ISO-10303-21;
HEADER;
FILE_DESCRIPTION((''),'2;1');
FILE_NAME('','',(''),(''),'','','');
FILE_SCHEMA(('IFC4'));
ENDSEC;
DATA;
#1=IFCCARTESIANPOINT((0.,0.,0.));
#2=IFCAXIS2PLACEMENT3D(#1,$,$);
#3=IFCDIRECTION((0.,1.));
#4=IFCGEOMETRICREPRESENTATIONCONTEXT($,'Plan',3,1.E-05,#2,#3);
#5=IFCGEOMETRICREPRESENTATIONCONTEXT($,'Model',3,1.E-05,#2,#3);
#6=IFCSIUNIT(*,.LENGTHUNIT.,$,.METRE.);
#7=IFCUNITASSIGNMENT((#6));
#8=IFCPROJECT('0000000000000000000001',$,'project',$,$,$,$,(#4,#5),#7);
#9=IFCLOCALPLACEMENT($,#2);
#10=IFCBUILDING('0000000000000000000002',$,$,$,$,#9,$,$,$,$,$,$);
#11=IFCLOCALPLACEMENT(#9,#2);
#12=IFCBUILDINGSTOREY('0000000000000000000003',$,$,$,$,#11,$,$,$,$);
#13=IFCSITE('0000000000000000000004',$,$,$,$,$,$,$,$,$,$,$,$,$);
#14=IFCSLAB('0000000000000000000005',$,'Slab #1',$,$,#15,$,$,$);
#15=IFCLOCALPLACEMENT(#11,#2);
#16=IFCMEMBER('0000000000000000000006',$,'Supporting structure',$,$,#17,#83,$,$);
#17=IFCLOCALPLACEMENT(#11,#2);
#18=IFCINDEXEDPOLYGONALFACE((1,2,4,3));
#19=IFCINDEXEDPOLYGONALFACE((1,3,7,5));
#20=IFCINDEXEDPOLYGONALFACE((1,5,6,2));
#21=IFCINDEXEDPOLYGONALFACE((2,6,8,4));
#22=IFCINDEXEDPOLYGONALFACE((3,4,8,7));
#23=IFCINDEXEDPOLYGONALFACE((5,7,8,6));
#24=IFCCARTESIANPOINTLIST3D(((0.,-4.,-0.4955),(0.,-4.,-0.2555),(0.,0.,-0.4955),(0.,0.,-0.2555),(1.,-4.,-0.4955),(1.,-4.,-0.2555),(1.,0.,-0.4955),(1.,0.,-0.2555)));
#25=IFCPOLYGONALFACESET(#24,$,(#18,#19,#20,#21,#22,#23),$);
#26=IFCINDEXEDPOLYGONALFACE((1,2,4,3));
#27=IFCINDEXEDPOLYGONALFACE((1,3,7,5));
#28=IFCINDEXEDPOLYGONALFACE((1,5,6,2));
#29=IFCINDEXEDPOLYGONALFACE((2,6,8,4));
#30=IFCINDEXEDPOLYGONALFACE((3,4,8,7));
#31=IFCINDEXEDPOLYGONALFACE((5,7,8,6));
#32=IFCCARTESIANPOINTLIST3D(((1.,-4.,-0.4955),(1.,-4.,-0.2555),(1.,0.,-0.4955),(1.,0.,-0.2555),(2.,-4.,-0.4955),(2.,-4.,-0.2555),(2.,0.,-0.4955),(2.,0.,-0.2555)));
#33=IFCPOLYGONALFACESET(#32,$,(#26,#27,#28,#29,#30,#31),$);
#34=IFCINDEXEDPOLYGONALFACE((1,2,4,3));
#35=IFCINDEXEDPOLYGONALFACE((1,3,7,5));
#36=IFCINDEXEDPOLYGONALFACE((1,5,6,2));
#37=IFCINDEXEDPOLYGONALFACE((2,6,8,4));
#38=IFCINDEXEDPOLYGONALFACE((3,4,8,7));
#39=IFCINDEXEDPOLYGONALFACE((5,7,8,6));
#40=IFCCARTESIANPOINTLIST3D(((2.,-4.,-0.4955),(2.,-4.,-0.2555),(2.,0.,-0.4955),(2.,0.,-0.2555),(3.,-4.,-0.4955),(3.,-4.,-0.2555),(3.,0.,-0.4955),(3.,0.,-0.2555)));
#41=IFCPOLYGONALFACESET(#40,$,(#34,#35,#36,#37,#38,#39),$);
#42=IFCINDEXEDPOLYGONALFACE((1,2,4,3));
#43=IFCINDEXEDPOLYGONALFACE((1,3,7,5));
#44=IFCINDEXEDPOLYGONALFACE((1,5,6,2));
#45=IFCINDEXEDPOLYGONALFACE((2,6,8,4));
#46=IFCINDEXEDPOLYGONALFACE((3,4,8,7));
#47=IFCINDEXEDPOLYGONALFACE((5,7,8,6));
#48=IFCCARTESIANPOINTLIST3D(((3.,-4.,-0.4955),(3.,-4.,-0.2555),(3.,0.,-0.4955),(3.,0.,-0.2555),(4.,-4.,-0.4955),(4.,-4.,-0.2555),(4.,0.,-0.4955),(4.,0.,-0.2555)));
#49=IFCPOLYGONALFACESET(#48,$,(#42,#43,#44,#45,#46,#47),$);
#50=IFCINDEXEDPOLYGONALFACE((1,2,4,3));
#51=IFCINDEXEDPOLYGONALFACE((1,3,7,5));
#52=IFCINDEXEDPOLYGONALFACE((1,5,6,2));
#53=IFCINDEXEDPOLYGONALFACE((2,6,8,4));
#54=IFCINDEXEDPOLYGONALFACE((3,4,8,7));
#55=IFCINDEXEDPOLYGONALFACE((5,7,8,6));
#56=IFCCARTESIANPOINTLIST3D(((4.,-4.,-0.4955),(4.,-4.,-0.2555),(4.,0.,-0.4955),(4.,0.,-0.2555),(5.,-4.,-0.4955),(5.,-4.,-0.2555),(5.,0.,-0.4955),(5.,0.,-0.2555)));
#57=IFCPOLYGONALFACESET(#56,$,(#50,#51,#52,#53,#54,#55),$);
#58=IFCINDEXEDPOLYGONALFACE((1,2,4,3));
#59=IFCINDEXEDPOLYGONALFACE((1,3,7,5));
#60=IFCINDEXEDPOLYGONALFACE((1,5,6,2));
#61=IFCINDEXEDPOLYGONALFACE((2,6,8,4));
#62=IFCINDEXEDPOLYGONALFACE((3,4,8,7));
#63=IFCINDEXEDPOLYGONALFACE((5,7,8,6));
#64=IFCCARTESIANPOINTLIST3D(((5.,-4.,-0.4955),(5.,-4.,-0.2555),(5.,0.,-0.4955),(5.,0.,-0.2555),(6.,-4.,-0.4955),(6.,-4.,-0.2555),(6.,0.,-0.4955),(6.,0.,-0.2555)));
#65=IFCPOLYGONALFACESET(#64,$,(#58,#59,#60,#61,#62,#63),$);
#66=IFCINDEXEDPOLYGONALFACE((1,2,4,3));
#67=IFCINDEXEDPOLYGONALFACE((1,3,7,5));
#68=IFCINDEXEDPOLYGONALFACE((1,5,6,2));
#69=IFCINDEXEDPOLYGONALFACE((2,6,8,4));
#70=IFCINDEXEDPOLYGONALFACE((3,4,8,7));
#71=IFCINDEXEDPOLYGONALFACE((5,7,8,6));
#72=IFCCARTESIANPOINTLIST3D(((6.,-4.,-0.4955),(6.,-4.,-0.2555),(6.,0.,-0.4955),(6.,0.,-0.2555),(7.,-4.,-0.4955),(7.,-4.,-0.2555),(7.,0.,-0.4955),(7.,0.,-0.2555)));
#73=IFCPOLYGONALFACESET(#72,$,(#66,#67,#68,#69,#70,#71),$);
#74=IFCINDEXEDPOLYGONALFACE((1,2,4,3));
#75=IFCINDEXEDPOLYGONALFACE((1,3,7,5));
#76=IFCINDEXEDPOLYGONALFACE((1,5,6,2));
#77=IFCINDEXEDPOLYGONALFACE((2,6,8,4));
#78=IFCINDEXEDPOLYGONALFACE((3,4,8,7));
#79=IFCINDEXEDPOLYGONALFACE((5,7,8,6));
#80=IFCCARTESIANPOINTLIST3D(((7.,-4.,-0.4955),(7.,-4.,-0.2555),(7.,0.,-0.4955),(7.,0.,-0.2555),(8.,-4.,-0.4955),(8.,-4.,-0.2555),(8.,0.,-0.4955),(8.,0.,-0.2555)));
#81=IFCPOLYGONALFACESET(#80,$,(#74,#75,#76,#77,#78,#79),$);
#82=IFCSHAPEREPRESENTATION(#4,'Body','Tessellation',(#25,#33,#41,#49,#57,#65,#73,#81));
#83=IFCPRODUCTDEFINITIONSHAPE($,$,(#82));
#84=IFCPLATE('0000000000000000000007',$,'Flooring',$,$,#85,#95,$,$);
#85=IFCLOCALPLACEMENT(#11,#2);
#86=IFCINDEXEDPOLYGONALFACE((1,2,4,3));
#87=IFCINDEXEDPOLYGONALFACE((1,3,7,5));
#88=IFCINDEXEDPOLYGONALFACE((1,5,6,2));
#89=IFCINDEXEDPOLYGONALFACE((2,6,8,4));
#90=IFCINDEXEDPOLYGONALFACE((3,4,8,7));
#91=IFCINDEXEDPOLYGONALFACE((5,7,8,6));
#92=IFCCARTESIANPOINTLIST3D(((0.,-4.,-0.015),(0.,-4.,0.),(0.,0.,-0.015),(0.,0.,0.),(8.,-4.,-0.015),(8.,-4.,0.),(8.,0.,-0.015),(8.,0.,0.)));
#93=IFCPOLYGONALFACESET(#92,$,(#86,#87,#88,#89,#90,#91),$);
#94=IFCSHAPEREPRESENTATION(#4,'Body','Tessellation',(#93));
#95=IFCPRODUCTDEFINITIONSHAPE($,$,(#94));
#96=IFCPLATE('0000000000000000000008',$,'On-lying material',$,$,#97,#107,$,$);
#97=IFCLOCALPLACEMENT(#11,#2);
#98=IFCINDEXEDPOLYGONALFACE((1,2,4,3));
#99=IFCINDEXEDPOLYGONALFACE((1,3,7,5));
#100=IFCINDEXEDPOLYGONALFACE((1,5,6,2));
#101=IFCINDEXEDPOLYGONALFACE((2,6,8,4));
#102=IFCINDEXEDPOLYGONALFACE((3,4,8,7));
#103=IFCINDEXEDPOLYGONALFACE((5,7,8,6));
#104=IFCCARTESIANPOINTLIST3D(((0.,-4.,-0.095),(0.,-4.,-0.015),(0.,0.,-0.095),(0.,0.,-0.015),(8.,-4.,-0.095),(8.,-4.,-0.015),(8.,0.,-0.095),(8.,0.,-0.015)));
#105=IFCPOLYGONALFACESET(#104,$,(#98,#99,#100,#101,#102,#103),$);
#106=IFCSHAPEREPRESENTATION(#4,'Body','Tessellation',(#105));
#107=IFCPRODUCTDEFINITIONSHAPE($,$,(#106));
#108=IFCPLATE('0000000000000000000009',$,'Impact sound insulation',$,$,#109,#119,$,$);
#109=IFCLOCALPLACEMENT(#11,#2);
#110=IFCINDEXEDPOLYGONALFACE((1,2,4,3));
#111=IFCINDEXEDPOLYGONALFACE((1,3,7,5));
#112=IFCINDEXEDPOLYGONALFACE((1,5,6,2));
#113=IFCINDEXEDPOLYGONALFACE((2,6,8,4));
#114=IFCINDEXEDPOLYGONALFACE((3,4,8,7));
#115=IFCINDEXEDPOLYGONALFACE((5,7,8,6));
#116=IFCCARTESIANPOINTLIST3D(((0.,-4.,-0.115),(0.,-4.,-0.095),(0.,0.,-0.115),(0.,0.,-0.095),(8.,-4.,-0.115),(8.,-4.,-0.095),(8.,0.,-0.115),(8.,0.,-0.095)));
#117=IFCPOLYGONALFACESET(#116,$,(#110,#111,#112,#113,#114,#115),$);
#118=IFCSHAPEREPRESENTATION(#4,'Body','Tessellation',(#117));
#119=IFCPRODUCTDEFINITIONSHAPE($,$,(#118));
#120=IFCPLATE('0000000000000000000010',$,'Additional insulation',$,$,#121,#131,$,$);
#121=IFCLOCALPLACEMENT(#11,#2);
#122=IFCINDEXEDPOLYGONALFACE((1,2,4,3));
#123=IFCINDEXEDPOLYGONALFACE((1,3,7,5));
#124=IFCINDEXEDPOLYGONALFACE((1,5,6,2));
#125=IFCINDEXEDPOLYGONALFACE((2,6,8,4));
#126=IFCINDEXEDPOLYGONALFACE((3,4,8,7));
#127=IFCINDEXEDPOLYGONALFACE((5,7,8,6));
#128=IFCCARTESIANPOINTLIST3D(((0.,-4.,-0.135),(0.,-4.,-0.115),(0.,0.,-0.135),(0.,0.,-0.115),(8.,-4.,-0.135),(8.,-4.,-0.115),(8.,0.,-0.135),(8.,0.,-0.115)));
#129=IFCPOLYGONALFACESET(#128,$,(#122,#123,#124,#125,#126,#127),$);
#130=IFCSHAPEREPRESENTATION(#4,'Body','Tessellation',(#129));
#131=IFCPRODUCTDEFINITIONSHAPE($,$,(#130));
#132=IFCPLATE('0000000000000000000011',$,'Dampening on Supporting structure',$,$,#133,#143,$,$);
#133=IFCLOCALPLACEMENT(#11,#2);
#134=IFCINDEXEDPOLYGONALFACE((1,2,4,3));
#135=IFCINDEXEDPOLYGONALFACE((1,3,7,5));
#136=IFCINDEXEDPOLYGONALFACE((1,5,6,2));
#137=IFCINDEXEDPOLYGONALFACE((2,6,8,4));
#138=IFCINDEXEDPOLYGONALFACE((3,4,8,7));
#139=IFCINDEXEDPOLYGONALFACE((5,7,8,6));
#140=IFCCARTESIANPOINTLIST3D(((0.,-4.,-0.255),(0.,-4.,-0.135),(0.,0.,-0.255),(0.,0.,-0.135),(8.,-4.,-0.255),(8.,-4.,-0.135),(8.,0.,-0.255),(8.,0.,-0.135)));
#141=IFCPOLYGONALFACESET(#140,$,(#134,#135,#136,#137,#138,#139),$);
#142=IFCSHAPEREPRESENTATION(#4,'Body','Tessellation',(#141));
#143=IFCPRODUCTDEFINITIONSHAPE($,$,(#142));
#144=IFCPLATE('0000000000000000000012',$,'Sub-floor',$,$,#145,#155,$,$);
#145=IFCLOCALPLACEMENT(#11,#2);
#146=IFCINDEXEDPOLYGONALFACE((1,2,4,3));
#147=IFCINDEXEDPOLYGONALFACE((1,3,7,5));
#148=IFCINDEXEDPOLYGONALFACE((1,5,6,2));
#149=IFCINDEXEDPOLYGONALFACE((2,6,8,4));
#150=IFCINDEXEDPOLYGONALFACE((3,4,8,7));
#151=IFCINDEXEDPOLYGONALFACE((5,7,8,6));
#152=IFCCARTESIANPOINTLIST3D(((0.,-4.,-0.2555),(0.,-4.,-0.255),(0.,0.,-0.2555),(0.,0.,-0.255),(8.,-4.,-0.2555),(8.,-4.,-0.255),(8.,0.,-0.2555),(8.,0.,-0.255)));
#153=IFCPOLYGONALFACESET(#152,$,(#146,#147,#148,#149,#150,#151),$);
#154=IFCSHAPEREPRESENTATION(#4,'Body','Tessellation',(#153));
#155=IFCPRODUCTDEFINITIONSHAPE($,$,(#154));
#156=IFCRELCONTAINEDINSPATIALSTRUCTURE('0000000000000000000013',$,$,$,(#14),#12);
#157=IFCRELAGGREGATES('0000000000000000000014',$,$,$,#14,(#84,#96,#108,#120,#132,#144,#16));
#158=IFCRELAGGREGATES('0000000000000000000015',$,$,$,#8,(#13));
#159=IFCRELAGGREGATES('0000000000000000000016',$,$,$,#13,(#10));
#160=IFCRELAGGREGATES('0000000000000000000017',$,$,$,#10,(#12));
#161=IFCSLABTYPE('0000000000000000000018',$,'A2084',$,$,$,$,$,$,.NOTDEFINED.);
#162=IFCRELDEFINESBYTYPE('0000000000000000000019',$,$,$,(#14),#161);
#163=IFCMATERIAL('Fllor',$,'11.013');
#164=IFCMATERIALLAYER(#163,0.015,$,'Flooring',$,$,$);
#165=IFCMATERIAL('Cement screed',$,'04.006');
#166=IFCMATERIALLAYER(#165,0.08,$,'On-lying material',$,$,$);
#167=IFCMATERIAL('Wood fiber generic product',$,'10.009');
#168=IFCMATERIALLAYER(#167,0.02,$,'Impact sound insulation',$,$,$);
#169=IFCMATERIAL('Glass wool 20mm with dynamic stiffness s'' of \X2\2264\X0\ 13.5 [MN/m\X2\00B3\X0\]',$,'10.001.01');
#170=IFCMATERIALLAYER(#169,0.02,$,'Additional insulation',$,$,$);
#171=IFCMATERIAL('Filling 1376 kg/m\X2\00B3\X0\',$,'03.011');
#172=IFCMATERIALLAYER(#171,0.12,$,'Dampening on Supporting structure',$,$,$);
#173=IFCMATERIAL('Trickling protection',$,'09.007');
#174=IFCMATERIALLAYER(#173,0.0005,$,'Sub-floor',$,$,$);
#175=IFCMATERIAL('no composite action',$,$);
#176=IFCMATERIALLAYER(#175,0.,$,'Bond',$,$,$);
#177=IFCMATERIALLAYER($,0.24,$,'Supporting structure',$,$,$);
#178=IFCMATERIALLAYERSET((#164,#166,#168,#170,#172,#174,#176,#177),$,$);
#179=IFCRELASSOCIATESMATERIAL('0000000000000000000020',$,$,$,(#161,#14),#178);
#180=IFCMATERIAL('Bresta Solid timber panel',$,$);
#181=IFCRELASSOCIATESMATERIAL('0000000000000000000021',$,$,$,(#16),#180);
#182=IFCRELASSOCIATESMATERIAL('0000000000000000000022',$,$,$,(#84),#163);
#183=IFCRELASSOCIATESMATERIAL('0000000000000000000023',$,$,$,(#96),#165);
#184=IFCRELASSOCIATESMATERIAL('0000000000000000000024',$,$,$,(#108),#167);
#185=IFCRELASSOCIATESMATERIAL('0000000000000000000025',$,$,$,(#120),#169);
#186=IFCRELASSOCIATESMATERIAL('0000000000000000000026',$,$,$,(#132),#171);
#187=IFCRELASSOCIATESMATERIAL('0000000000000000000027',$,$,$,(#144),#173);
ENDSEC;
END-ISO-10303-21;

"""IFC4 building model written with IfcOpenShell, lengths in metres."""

from ifc_helpers import new_model, si_unit, direction, frame, frame_2d, origin, origin_with_axes, place, context, project, spatial, rectangle, extrude, material, layer, layer_set, type_object, element, aggregate, save


model = new_model("IFC4")

# Units and contexts
plan_context = context("Plan", 3, precision=1e-05, world=origin(), true_north=direction((0.0, 1.0)))
model_context = context("Model", 3, precision=1e-05, world=origin(), true_north=direction((0.0, 1.0)))
ifc_project = project(units=[si_unit("LENGTHUNIT", "METRE")], contexts=[plan_context, model_context])

# Site, building, storey
site = spatial("IfcSite", under=ifc_project)
building_placement = place(None, origin())
building = spatial("IfcBuilding", under=site, at=building_placement)
storey_placement = place(building_placement, origin())
storey = spatial("IfcBuildingStorey", under=building, at=storey_placement)

# Slab, member, plates
ifc_material_1 = material(Name="Fllor", Category="11.013")
ifc_layer_1 = layer(ifc_material_1, 0.015, Name="Flooring")
ifc_material_2 = material(Name="Cement screed", Category="04.006")
ifc_layer_2 = layer(ifc_material_2, 0.08, Name="On-lying material")
ifc_material_3 = material(Name="Wood fiber generic product", Category="10.009")
ifc_layer_3 = layer(ifc_material_3, 0.02, Name="Impact sound insulation")
ifc_material_4 = material(Name="Glass wool 20mm with dynamic stiffness s' of ≤ 13.5 [MN/m³]", Category="10.001.01")
ifc_layer_4 = layer(ifc_material_4, 0.02, Name="Additional insulation")
ifc_material_5 = material(Name="Filling 1376 kg/m³", Category="03.011")
ifc_layer_5 = layer(ifc_material_5, 0.12, Name="Dampening on Supporting structure")
ifc_material_6 = material(Name="Trickling protection", Category="09.007")
ifc_layer_6 = layer(ifc_material_6, 0.0005, Name="Sub-floor")
ifc_material_7 = material(Name="no composite action")
ifc_layer_7 = layer(ifc_material_7, 0.0, Name="Bond")
ifc_layer_8 = layer(None, 0.24, Name="Supporting structure")
ifc_layer_set = layer_set([ifc_layer_1, ifc_layer_2, ifc_layer_3, ifc_layer_4, ifc_layer_5, ifc_layer_6, ifc_layer_7, ifc_layer_8])
slab_type = type_object("IfcSlabType", Name="A2084", PredefinedType="NOTDEFINED", material=ifc_layer_set)
slab_placement = place(None, frame((0.0, 0.0, 0.0), z_axis=(0.0, 0.0, -1.0), x_axis=(1.0, 0.0, 0.0)))
slab = element("IfcSlab", 1, at=slab_placement, inside=storey, type_object=slab_type, material=ifc_layer_set, Name="Slab #1")
ifc_material_8 = material(Name="Bresta Solid timber panel")
member_placement = place(slab_placement, origin())
member = element("IfcMember", 2, at=member_placement, material=ifc_material_8, Name="Supporting structure", context=plan_context, shape_type="SweptSolid", body=[
    extrude(rectangle(XDim=1.0, YDim=0.24, at=frame_2d((0.5, 0.12), x_axis=(1.0, 0.0))), frame((0.0, 4.0, 0.2555), z_axis=(0.0, -1.0, 0.0), x_axis=(1.0, 0.0, 0.0)), (0.0, 0.0, 1.0), 4.0),
    extrude(rectangle(XDim=1.0, YDim=0.24, at=frame_2d((0.5, 0.12), x_axis=(1.0, 0.0))), frame((1.0, 4.0, 0.2555), z_axis=(0.0, -1.0, 0.0), x_axis=(1.0, 0.0, 0.0)), (0.0, 0.0, 1.0), 4.0),
    extrude(rectangle(XDim=1.0, YDim=0.24, at=frame_2d((0.5, 0.12), x_axis=(1.0, 0.0))), frame((2.0, 4.0, 0.2555), z_axis=(0.0, -1.0, 0.0), x_axis=(1.0, 0.0, 0.0)), (0.0, 0.0, 1.0), 4.0),
    extrude(rectangle(XDim=1.0, YDim=0.24, at=frame_2d((0.5, 0.12), x_axis=(1.0, 0.0))), frame((3.0, 4.0, 0.2555), z_axis=(0.0, -1.0, 0.0), x_axis=(1.0, 0.0, 0.0)), (0.0, 0.0, 1.0), 4.0),
    extrude(rectangle(XDim=1.0, YDim=0.24, at=frame_2d((0.5, 0.12), x_axis=(1.0, 0.0))), frame((4.0, 4.0, 0.2555), z_axis=(0.0, -1.0, 0.0), x_axis=(1.0, 0.0, 0.0)), (0.0, 0.0, 1.0), 4.0),
    extrude(rectangle(XDim=1.0, YDim=0.24, at=frame_2d((0.5, 0.12), x_axis=(1.0, 0.0))), frame((5.0, 4.0, 0.2555), z_axis=(0.0, -1.0, 0.0), x_axis=(1.0, 0.0, 0.0)), (0.0, 0.0, 1.0), 4.0),
    extrude(rectangle(XDim=1.0, YDim=0.24, at=frame_2d((0.5, 0.12), x_axis=(1.0, 0.0))), frame((6.0, 4.0, 0.2555), z_axis=(0.0, -1.0, 0.0), x_axis=(1.0, 0.0, 0.0)), (0.0, 0.0, 1.0), 4.0),
    extrude(rectangle(XDim=1.0, YDim=0.24, at=frame_2d((0.5, 0.12), x_axis=(1.0, 0.0))), frame((7.0, 4.0, 0.2555), z_axis=(0.0, -1.0, 0.0), x_axis=(1.0, 0.0, 0.0)), (0.0, 0.0, 1.0), 4.0),
])
plate_1_placement = place(slab_placement, origin())
plate_1 = element("IfcPlate", 3, at=plate_1_placement, material=ifc_material_1, Name="Flooring", context=plan_context, shape_type="SweptSolid", body=[
    extrude(rectangle(XDim=8.0, YDim=4.0, at=frame_2d((4.0, 2.0), x_axis=(1.0, 0.0))), origin_with_axes(), (0.0, 0.0, 1.0), 0.015),
])
plate_2_placement = place(slab_placement, origin())
plate_2 = element("IfcPlate", 4, at=plate_2_placement, material=ifc_material_2, Name="On-lying material", context=plan_context, shape_type="SweptSolid", body=[
    extrude(rectangle(XDim=8.0, YDim=4.0, at=frame_2d((4.0, 2.0), x_axis=(1.0, 0.0))), frame((0.0, 0.0, 0.015), z_axis=(0.0, 0.0, 1.0), x_axis=(1.0, 0.0, 0.0)), (0.0, 0.0, 1.0), 0.08),
])
plate_3_placement = place(slab_placement, origin())
plate_3 = element("IfcPlate", 5, at=plate_3_placement, material=ifc_material_3, Name="Impact sound insulation", context=plan_context, shape_type="SweptSolid", body=[
    extrude(rectangle(XDim=8.0, YDim=4.0, at=frame_2d((4.0, 2.0), x_axis=(1.0, 0.0))), frame((0.0, 0.0, 0.095), z_axis=(0.0, 0.0, 1.0), x_axis=(1.0, 0.0, 0.0)), (0.0, 0.0, 1.0), 0.02),
])
plate_4_placement = place(slab_placement, origin())
plate_4 = element("IfcPlate", 6, at=plate_4_placement, material=ifc_material_4, Name="Additional insulation", context=plan_context, shape_type="SweptSolid", body=[
    extrude(rectangle(XDim=8.0, YDim=4.0, at=frame_2d((4.0, 2.0), x_axis=(1.0, 0.0))), frame((0.0, 0.0, 0.115), z_axis=(0.0, 0.0, 1.0), x_axis=(1.0, 0.0, 0.0)), (0.0, 0.0, 1.0), 0.02),
])
plate_5_placement = place(slab_placement, origin())
plate_5 = element("IfcPlate", 7, at=plate_5_placement, material=ifc_material_5, Name="Dampening on Supporting structure", context=plan_context, shape_type="SweptSolid", body=[
    extrude(rectangle(XDim=8.0, YDim=4.0, at=frame_2d((4.0, 2.0), x_axis=(1.0, 0.0))), frame((0.0, 0.0, 0.135), z_axis=(0.0, 0.0, 1.0), x_axis=(1.0, 0.0, 0.0)), (0.0, 0.0, 1.0), 0.12),
])
plate_6_placement = place(slab_placement, origin())
plate_6 = element("IfcPlate", 8, at=plate_6_placement, material=ifc_material_6, Name="Sub-floor", context=plan_context, shape_type="SweptSolid", body=[
    extrude(rectangle(XDim=8.0, YDim=4.0, at=frame_2d((4.0, 2.0), x_axis=(1.0, 0.0))), frame((0.0, 0.0, 0.255), z_axis=(0.0, 0.0, 1.0), x_axis=(1.0, 0.0, 0.0)), (0.0, 0.0, 1.0), 0.0005),
])
aggregate(slab, [plate_1, plate_2, plate_3, plate_4, plate_5, plate_6, member])

save(model, "model.ifc")
